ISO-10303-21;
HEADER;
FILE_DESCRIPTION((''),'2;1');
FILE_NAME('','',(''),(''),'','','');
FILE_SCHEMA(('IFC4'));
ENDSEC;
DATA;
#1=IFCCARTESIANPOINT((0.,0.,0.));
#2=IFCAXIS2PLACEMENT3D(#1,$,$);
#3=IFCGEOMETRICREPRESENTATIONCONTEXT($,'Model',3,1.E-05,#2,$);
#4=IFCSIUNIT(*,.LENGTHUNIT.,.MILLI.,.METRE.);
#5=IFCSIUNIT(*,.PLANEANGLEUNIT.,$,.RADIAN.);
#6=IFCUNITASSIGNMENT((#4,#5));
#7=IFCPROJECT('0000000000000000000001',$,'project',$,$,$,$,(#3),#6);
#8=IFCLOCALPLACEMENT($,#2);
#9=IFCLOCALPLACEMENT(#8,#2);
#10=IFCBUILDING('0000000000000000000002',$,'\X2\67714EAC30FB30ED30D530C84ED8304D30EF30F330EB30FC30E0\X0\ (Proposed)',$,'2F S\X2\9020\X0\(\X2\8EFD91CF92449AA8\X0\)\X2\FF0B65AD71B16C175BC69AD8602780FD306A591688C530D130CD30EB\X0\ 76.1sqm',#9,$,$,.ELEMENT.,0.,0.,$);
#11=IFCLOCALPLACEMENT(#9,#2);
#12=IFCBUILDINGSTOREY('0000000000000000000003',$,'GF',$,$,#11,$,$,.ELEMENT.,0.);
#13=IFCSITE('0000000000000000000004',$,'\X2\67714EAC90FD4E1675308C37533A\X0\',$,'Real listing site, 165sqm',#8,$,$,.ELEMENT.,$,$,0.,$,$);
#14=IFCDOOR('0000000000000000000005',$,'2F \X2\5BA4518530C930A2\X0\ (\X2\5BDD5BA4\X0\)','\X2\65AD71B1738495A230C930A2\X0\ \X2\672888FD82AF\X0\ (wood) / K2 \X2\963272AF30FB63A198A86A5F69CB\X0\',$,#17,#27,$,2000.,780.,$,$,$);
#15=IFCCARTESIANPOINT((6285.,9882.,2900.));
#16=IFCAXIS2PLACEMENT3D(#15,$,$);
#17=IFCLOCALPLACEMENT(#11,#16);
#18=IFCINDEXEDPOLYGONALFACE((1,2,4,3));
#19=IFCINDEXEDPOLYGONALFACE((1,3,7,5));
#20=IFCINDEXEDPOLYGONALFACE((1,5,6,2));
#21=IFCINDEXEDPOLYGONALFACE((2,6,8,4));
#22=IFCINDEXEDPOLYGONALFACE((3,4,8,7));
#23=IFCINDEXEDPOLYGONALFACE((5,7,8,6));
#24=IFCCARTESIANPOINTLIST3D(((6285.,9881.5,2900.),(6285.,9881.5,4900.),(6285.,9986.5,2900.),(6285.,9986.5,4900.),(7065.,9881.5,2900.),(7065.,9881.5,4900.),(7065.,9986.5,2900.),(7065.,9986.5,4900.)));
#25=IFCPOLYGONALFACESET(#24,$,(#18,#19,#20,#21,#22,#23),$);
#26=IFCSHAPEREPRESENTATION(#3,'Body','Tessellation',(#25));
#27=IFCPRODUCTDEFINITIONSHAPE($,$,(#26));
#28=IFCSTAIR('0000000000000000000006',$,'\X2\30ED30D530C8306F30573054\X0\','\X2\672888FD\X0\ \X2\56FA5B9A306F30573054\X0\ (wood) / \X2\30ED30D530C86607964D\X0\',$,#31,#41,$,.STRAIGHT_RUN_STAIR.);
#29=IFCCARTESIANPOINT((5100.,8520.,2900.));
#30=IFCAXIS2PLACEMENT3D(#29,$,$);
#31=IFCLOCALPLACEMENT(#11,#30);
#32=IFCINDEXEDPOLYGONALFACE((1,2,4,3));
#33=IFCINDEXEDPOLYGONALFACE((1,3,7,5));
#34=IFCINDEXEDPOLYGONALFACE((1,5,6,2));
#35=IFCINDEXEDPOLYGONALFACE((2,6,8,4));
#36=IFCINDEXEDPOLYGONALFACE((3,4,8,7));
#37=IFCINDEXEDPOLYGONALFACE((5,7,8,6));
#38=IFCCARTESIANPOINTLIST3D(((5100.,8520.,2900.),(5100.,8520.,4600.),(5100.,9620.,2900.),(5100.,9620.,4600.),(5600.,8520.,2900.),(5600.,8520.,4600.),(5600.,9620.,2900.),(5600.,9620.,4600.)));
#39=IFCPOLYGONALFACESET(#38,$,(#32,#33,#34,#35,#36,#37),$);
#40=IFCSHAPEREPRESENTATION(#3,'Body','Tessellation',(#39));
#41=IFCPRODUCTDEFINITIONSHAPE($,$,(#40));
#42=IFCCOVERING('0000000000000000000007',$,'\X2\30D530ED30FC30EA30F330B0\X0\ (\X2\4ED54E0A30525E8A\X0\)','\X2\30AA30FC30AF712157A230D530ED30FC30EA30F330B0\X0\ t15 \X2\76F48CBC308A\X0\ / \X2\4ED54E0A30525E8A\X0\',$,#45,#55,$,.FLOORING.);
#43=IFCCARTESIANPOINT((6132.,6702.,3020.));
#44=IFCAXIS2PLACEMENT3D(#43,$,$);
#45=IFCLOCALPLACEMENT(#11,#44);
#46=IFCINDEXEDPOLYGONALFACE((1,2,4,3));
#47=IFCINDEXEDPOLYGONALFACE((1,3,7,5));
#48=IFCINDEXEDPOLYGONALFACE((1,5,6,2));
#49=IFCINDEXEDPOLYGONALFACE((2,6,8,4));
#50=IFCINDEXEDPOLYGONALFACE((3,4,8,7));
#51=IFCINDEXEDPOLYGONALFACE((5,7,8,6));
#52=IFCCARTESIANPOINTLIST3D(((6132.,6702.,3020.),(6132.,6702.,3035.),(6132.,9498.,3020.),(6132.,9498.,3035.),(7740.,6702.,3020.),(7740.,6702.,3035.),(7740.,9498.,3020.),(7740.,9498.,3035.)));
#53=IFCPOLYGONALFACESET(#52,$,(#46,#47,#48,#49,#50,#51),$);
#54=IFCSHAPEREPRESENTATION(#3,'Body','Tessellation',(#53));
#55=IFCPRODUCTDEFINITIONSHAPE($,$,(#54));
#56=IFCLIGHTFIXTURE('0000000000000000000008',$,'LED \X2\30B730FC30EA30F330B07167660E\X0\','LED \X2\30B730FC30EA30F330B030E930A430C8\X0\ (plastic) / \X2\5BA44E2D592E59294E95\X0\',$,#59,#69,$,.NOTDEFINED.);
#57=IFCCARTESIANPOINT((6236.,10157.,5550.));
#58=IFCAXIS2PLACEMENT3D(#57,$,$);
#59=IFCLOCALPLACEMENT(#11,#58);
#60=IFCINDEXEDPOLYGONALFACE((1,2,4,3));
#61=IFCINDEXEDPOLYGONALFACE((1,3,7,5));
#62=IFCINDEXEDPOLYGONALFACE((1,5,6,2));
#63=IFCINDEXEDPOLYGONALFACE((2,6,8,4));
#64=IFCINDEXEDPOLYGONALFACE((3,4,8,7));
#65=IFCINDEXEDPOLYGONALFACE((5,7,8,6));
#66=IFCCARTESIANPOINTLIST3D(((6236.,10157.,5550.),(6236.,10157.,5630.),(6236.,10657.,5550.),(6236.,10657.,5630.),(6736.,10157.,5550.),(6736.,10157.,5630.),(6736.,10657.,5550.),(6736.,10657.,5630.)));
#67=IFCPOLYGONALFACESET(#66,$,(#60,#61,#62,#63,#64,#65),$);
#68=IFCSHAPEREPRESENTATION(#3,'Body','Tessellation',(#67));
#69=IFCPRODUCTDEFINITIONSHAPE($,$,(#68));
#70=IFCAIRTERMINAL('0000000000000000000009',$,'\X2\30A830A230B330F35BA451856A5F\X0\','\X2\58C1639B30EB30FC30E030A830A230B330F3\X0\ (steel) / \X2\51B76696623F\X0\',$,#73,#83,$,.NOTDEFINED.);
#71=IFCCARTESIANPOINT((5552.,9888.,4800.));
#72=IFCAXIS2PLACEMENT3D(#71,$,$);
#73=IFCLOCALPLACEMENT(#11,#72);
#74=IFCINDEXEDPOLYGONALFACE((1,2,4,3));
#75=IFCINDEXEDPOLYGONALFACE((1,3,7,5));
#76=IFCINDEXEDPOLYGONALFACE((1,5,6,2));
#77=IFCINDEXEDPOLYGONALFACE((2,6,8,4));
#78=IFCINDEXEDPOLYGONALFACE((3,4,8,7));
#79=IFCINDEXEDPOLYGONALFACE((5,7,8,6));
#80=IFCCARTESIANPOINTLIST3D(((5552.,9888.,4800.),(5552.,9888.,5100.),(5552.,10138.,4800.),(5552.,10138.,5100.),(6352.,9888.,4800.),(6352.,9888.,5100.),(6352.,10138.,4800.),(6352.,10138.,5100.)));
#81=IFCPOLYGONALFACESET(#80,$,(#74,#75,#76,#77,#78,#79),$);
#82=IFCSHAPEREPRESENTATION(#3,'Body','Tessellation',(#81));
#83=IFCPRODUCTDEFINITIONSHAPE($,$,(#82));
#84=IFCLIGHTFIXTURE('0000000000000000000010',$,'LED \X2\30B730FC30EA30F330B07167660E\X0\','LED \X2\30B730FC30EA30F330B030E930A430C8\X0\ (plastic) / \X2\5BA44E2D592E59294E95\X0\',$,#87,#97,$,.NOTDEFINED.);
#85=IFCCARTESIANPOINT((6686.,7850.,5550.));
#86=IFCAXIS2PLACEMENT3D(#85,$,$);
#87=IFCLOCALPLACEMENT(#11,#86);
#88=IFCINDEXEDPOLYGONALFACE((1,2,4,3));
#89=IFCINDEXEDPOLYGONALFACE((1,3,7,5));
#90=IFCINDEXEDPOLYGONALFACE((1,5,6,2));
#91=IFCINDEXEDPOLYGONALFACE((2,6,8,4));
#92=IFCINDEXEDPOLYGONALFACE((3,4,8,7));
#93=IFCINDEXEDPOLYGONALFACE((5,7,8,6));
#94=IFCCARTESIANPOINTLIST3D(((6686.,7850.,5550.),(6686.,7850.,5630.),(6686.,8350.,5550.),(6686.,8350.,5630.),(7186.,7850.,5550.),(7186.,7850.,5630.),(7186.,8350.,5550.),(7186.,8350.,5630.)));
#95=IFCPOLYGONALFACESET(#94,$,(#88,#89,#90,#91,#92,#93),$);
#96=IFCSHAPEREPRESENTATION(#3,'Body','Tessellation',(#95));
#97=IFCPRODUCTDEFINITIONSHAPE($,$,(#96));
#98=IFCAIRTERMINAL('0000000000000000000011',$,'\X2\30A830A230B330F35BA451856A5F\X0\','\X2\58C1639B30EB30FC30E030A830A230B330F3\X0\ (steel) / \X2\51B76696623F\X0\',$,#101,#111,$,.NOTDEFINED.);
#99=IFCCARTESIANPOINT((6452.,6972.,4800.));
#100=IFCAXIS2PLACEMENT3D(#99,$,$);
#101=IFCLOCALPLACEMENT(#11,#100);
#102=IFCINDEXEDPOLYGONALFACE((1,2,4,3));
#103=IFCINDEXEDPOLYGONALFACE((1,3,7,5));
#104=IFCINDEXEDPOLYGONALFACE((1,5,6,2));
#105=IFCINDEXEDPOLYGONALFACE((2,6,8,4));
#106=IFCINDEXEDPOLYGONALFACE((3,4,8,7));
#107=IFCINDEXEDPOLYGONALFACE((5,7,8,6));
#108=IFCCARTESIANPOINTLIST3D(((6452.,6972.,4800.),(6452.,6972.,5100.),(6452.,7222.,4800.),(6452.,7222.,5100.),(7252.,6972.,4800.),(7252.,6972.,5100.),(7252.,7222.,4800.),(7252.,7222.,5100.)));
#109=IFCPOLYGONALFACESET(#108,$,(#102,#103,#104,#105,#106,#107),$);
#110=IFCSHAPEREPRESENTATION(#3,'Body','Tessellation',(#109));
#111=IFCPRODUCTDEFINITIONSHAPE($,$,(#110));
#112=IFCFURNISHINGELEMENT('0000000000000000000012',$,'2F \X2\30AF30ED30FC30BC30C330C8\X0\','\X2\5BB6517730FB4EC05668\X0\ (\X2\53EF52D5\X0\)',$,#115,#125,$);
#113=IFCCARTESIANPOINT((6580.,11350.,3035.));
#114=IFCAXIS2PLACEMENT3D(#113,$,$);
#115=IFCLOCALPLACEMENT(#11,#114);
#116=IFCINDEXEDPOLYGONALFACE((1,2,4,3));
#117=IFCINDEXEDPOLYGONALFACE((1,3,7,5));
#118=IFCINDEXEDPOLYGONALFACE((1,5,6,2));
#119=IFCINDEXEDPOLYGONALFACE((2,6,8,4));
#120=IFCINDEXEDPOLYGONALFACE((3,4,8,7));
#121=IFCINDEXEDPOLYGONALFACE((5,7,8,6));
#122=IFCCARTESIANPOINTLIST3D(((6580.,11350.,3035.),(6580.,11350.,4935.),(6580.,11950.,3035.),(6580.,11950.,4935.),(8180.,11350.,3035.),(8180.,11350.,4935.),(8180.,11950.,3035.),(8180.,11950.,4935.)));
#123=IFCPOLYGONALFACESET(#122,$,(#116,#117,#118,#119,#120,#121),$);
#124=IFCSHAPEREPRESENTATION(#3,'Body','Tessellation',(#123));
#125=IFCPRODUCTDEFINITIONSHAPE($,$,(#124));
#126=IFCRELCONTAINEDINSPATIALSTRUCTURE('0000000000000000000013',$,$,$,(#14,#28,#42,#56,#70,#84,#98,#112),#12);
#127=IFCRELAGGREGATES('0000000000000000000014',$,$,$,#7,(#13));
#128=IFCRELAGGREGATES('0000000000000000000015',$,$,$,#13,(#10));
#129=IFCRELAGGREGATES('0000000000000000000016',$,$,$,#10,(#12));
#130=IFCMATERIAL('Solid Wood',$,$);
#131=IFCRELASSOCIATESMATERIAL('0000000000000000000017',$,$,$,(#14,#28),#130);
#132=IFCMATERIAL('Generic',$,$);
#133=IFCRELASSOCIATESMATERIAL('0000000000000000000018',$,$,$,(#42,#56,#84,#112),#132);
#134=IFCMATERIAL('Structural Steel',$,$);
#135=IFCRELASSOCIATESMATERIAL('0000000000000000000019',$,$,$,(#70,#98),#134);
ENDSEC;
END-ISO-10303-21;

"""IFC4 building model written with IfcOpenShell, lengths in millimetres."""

from ifc_helpers import new_model, si_unit, frame, frame_2d, origin, place, context, project, spatial, rectangle, extrude, material, element, save


model = new_model("IFC4")

# Units and contexts
model_context = context("Model", 3, precision=1e-05, world=origin())
ifc_project = project(units=[si_unit("LENGTHUNIT", "METRE", prefix="MILLI"), si_unit("PLANEANGLEUNIT", "RADIAN")], contexts=[model_context])

# Site, building, storey
site_placement = place(None, origin())
site = spatial("IfcSite", under=ifc_project, at=site_placement, Name="東京都世田谷区", ObjectType="Real listing site, 165sqm", CompositionType="ELEMENT", RefElevation=0.0)
building_placement = place(site_placement, origin())
building = spatial("IfcBuilding", under=site, at=building_placement, Name="東京・ロフト付きワンルーム (Proposed)", ObjectType="2F S造(軽量鉄骨)＋断熱気密高性能な外装パネル 76.1sqm", CompositionType="ELEMENT", ElevationOfRefHeight=0.0, ElevationOfTerrain=0.0)
storey_placement = place(building_placement, origin())
storey = spatial("IfcBuildingStorey", under=building, at=storey_placement, Name="GF", CompositionType="ELEMENT", Elevation=0.0)

# Shared definitions
ifc_material_1 = material(Name="Solid Wood")

# Door
door_placement = place(storey_placement, frame((6285.0, 9882.0, 2900.0)))
element("IfcDoor", 1, at=door_placement, inside=storey, material=ifc_material_1, Name="2F 室内ドア (寝室)", Description="断熱玄関ドア 木製芯 (wood) / K2 防犯・採風機構", OverallHeight=2000.0, OverallWidth=780.0, context=model_context, shape_type="SweptSolid", body=[
    extrude(rectangle(XDim=780.0, YDim=105.0, at=frame_2d((390.0, 52.0))), frame((6285.0, 9882.0, 2900.0)), (0.0, 0.0, 1.0), 2000.0),
])

# Stair
stair_placement = place(storey_placement, frame((5100.0, 8520.0, 2900.0)))
element("IfcStair", 2, at=stair_placement, inside=storey, material=ifc_material_1, Name="ロフトはしご", Description="木製 固定はしご (wood) / ロフト昇降", PredefinedType="STRAIGHT_RUN_STAIR", context=model_context, shape_type="SweptSolid", body=[
    extrude(rectangle(XDim=500.0, YDim=1100.0, at=frame_2d((250.0, 550.0))), frame((5100.0, 8520.0, 2900.0)), (0.0, 0.0, 1.0), 1700.0),
])

# Covering
ifc_material_2 = material(Name="Generic")
covering_placement = place(storey_placement, frame((6132.0, 6702.0, 3020.0)))
element("IfcCovering", 3, at=covering_placement, inside=storey, material=ifc_material_2, Name="フローリング (仕上げ床)", Description="オーク無垢フローリング t15 直貼り / 仕上げ床", PredefinedType="FLOORING", context=model_context, shape_type="SweptSolid", body=[
    extrude(rectangle(XDim=1608.0, YDim=2796.0, at=frame_2d((804.0, 1398.0))), frame((6132.0, 6702.0, 3020.0)), (0.0, 0.0, 1.0), 15.0),
])

# Light fixture
light_fixture_1_placement = place(storey_placement, frame((6236.0, 10157.0, 5550.0)))
element("IfcLightFixture", 4, at=light_fixture_1_placement, inside=storey, material=ifc_material_2, Name="LED シーリング照明", Description="LED シーリングライト (plastic) / 室中央天井", PredefinedType="NOTDEFINED", context=model_context, shape_type="SweptSolid", body=[
    extrude(rectangle(XDim=500.0, YDim=500.0, at=frame_2d((250.0, 250.0))), frame((6236.0, 10157.0, 5550.0)), (0.0, 0.0, 1.0), 80.0),
])

# Air terminal
ifc_material_3 = material(Name="Structural Steel")
air_terminal_1_placement = place(storey_placement, frame((5552.0, 9888.0, 4800.0)))
element("IfcAirTerminal", 5, at=air_terminal_1_placement, inside=storey, material=ifc_material_3, Name="エアコン室内機", Description="壁掛ルームエアコン (steel) / 冷暖房", PredefinedType="NOTDEFINED", context=model_context, shape_type="SweptSolid", body=[
    extrude(rectangle(XDim=800.0, YDim=250.0, at=frame_2d((400.0, 125.0))), frame((5552.0, 9888.0, 4800.0)), (0.0, 0.0, 1.0), 300.0),
])

# Light fixture
light_fixture_2_placement = place(storey_placement, frame((6686.0, 7850.0, 5550.0)))
element("IfcLightFixture", 6, at=light_fixture_2_placement, inside=storey, material=ifc_material_2, Name="LED シーリング照明", Description="LED シーリングライト (plastic) / 室中央天井", PredefinedType="NOTDEFINED", context=model_context, shape_type="SweptSolid", body=[
    extrude(rectangle(XDim=500.0, YDim=500.0, at=frame_2d((250.0, 250.0))), frame((6686.0, 7850.0, 5550.0)), (0.0, 0.0, 1.0), 80.0),
])

# Air terminal
air_terminal_2_placement = place(storey_placement, frame((6452.0, 6972.0, 4800.0)))
element("IfcAirTerminal", 7, at=air_terminal_2_placement, inside=storey, material=ifc_material_3, Name="エアコン室内機", Description="壁掛ルームエアコン (steel) / 冷暖房", PredefinedType="NOTDEFINED", context=model_context, shape_type="SweptSolid", body=[
    extrude(rectangle(XDim=800.0, YDim=250.0, at=frame_2d((400.0, 125.0))), frame((6452.0, 6972.0, 4800.0)), (0.0, 0.0, 1.0), 300.0),
])

# Furnishing element
furnishing_placement = place(storey_placement, frame((6580.0, 11350.0, 3035.0)))
element("IfcFurnishingElement", 8, at=furnishing_placement, inside=storey, material=ifc_material_2, Name="2F クローゼット", Description="家具・什器 (可動)", context=model_context, shape_type="SweptSolid", body=[
    extrude(rectangle(XDim=1600.0, YDim=600.0, at=frame_2d((800.0, 300.0))), frame((6580.0, 11350.0, 3035.0)), (0.0, 0.0, 1.0), 1900.0),
])

save(model, "model.ifc")
